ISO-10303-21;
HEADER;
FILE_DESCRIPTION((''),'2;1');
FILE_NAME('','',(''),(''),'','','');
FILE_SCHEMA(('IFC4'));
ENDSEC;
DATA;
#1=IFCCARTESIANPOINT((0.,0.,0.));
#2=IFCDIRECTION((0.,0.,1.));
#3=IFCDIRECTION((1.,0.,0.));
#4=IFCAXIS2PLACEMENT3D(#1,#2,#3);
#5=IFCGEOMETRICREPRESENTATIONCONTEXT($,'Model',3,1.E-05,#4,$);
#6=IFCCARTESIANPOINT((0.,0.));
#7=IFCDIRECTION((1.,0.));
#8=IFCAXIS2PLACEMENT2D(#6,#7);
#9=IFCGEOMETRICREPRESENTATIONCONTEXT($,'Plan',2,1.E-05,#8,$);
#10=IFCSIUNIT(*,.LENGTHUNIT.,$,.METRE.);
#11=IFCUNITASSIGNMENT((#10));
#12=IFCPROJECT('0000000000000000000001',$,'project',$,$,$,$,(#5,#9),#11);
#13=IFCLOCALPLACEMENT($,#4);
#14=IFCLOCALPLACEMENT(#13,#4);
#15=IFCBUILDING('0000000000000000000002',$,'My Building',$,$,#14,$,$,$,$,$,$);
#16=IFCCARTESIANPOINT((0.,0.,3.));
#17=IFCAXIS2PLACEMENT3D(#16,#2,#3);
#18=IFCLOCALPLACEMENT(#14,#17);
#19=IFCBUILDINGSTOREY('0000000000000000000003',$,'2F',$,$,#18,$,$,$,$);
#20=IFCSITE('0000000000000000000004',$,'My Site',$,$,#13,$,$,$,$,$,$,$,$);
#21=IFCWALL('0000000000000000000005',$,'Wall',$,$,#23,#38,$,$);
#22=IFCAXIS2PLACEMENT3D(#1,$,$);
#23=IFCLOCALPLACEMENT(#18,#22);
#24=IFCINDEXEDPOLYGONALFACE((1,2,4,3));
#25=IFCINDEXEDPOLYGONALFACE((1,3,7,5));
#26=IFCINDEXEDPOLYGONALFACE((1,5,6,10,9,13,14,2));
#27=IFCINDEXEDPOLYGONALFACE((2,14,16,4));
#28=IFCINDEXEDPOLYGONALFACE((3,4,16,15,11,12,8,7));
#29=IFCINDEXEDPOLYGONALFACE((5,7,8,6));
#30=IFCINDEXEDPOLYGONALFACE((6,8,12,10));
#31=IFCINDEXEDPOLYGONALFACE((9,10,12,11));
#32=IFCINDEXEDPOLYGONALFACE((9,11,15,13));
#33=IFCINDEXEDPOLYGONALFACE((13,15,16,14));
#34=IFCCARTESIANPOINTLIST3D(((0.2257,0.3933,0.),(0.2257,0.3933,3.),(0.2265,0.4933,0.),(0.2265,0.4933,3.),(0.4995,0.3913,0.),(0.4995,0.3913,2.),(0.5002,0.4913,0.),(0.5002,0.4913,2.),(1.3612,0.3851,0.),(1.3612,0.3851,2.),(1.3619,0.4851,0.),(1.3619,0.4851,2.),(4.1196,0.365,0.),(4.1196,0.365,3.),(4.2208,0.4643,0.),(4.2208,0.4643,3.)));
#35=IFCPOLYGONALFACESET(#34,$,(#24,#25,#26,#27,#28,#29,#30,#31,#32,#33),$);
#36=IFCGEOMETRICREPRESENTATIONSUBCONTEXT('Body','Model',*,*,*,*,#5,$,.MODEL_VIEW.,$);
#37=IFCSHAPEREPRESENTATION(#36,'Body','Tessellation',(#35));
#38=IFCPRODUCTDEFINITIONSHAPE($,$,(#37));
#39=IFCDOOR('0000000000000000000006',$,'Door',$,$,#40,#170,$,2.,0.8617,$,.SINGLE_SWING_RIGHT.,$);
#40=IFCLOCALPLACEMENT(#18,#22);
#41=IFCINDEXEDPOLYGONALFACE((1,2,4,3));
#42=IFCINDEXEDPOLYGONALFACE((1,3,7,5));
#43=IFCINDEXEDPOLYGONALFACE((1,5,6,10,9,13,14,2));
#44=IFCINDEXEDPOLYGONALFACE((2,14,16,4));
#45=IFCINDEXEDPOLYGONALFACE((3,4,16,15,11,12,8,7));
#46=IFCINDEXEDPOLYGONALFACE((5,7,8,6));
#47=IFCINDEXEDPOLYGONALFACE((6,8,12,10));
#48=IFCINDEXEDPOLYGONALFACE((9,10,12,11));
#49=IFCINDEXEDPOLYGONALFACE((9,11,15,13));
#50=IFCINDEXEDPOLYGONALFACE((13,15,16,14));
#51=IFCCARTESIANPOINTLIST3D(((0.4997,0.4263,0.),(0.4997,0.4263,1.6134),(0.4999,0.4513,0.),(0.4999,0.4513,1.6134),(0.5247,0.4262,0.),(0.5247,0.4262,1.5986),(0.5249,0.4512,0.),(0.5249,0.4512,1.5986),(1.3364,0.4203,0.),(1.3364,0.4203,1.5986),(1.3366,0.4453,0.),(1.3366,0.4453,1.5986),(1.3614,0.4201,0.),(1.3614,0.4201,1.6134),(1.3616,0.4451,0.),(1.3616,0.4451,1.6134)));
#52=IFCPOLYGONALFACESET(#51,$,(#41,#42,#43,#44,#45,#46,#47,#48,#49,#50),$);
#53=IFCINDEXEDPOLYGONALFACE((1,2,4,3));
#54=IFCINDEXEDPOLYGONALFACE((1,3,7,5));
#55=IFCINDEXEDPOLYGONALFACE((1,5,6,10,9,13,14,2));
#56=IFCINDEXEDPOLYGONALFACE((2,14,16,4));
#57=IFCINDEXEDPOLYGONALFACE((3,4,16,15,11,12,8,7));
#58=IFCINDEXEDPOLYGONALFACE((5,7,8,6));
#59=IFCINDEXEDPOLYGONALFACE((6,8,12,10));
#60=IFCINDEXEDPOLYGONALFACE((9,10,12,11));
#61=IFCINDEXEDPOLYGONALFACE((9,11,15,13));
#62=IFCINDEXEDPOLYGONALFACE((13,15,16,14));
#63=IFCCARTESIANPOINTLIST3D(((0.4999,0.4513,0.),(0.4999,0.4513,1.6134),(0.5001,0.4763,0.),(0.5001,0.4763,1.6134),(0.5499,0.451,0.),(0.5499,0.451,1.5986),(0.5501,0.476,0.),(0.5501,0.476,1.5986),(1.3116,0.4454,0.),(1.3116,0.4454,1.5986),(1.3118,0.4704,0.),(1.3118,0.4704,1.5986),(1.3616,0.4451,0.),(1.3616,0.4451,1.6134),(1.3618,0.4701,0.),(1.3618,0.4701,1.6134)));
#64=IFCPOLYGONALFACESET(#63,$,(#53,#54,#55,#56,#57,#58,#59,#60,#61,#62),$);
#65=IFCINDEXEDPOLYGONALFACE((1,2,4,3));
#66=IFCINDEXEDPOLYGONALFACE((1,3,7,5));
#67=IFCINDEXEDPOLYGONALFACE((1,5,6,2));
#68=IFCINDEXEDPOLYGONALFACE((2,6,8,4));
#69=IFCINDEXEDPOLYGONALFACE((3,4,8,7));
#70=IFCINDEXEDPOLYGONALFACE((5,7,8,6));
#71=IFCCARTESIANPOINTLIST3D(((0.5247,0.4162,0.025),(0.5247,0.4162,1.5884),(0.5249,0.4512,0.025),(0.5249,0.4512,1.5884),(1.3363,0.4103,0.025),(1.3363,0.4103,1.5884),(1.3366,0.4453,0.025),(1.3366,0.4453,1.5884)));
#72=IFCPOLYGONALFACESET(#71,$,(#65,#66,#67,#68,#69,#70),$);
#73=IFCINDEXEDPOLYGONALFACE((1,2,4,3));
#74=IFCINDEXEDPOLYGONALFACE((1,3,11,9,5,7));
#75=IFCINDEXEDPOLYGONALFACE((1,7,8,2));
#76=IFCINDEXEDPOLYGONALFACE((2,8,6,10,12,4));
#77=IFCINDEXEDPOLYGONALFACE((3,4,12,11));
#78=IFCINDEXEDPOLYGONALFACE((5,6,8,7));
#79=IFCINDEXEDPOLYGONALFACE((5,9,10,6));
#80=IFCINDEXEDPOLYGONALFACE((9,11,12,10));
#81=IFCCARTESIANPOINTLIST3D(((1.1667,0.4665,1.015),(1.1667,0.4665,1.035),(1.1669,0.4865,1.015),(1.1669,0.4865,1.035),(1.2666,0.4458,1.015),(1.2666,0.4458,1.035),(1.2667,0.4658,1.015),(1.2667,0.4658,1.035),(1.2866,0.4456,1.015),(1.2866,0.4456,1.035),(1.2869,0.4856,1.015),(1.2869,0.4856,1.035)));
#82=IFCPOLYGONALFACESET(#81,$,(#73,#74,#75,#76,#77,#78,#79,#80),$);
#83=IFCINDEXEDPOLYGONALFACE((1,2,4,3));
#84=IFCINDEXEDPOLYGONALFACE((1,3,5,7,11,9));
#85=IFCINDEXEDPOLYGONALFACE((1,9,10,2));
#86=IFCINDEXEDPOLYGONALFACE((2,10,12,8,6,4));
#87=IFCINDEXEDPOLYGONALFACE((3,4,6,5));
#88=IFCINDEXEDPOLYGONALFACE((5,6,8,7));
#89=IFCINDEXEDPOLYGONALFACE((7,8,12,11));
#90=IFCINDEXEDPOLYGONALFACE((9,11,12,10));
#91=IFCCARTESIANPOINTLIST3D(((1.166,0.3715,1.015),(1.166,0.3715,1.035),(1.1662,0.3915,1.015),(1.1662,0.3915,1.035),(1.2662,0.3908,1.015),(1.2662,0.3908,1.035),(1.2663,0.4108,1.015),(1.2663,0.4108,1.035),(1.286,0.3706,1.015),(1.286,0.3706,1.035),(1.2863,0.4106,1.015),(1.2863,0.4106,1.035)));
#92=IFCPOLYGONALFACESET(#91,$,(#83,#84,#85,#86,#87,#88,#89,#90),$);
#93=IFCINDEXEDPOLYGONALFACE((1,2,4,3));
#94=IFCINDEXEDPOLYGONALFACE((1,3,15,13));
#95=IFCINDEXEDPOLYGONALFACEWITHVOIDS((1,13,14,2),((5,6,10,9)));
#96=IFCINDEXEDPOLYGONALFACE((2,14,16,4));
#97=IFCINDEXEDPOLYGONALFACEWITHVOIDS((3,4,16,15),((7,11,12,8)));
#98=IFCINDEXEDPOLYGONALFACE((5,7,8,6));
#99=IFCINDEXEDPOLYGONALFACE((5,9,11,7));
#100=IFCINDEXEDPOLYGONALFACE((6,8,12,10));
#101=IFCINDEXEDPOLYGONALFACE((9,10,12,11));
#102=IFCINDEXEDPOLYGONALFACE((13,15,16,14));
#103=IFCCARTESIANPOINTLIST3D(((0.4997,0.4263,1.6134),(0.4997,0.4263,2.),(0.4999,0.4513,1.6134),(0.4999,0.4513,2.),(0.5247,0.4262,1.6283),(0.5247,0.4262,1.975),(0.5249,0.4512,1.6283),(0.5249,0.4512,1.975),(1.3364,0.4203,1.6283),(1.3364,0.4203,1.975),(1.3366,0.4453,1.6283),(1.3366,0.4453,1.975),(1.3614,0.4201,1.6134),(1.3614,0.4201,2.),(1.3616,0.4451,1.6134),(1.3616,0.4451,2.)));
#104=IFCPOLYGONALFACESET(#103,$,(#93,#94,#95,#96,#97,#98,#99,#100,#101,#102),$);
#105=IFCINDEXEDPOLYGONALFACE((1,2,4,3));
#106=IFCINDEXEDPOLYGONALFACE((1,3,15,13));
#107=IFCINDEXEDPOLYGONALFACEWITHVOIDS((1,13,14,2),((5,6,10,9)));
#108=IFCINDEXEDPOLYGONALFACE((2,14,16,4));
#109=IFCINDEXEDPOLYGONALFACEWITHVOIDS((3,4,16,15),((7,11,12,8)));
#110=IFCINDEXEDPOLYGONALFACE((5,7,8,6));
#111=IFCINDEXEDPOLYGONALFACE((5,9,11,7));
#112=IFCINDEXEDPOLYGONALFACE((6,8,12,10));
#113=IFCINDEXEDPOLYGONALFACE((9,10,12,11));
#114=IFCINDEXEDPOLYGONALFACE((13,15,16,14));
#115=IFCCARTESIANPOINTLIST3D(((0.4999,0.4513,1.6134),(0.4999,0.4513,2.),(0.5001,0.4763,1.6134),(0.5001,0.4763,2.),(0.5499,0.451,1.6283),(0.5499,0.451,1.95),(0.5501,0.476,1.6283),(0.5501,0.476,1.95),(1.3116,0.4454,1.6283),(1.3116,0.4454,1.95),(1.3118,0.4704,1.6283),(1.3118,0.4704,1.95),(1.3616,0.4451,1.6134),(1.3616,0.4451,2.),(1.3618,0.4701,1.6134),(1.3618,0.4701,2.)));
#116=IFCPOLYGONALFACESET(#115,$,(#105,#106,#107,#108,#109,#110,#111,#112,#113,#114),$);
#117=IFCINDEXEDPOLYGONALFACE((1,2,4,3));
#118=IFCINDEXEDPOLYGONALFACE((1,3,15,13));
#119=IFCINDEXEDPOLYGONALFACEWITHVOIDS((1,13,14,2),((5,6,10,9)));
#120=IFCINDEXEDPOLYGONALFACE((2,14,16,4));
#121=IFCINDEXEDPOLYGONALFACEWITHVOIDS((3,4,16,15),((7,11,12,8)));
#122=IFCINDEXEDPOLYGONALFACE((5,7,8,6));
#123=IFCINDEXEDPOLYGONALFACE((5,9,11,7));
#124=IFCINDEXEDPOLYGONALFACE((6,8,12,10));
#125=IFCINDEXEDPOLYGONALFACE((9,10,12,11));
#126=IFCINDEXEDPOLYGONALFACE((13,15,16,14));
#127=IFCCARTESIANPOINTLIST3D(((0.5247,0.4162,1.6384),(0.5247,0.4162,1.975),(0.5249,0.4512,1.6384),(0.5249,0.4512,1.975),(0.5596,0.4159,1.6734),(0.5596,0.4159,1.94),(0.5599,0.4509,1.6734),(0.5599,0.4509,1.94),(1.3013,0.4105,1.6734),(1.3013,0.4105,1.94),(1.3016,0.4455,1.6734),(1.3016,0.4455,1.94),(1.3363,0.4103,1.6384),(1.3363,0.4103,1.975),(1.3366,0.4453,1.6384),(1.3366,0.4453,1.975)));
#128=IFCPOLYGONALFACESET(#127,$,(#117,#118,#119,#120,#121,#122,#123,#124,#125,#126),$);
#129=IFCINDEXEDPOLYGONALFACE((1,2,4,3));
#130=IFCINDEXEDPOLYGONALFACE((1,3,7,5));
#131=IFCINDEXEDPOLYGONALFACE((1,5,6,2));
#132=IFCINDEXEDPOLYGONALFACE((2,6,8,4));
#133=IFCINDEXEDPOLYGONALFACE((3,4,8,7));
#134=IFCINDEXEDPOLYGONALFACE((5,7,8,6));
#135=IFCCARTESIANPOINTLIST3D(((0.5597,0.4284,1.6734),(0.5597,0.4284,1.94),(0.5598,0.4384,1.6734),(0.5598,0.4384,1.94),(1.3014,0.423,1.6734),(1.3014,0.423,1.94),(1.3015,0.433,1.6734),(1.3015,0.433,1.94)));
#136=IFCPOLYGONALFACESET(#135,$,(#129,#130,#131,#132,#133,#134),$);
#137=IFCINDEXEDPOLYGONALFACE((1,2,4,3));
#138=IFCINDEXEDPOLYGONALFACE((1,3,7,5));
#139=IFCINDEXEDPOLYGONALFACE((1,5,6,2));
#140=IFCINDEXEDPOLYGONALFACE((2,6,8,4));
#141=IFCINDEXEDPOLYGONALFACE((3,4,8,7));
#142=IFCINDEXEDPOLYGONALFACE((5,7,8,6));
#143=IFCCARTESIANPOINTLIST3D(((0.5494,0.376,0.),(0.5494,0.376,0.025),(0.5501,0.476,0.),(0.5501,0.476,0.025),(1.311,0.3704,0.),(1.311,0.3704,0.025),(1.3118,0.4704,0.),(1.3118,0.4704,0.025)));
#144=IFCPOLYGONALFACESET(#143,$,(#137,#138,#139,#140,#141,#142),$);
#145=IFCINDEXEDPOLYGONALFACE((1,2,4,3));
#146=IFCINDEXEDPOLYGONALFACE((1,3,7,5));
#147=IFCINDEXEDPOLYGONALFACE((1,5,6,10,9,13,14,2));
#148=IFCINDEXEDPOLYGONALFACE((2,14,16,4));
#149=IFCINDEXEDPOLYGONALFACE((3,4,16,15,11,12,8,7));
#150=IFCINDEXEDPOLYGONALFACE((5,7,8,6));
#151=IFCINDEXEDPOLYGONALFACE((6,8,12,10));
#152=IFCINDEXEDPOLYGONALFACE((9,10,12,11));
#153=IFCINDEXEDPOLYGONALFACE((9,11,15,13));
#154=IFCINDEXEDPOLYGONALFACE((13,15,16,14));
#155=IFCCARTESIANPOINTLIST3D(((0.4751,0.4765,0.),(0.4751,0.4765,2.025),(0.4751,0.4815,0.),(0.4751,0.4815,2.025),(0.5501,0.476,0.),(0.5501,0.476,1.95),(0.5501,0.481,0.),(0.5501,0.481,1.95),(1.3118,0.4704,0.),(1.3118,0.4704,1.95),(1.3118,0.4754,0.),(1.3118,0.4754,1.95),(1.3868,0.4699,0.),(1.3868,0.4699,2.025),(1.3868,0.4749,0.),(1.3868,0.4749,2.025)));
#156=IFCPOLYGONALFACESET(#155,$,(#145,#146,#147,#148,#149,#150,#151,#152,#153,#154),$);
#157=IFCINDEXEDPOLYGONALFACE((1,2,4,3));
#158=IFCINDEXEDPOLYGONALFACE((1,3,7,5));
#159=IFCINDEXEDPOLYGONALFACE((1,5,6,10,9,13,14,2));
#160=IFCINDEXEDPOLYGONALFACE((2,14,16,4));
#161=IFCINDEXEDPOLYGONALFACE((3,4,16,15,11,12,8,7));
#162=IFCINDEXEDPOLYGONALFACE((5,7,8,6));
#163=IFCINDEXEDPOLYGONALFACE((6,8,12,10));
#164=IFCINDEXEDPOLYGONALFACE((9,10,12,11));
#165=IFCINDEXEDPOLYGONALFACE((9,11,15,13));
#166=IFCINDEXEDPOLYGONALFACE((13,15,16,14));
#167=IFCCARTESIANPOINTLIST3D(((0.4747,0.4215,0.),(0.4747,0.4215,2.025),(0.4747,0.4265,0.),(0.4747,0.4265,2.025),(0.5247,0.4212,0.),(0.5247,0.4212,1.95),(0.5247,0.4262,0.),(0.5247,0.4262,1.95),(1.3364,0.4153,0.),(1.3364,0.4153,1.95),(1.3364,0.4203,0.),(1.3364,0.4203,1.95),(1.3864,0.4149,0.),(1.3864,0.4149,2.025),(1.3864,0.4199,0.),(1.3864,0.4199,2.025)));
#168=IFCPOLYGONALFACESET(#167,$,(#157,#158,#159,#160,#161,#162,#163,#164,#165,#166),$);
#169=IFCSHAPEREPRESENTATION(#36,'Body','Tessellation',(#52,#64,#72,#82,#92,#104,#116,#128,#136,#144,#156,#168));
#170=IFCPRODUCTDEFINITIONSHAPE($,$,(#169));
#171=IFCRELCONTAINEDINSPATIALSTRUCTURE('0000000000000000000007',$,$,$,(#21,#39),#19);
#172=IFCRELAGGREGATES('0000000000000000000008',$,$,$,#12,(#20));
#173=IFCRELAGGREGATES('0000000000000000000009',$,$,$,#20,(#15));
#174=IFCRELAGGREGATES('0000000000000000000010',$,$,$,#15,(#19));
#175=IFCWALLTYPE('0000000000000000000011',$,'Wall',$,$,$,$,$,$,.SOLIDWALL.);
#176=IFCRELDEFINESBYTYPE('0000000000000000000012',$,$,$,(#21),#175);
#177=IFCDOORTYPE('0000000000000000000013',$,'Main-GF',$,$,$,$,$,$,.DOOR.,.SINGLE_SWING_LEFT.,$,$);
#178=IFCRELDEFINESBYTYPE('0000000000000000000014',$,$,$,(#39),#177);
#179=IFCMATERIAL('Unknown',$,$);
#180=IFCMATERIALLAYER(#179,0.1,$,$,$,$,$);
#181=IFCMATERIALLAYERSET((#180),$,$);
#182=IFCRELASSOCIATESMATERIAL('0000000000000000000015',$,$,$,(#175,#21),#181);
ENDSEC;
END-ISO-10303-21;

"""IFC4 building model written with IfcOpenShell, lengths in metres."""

from ifc_helpers import new_model, entity, si_unit, frame, origin_with_axes, origin_2d_with_axis, place, context, subcontext, project, spatial, line, indexed_curve, outline, extrude, shape, source, transform, mapped, material, layer, layer_set, layer_usage, type_object, type_shapes, element, fill, save


model = new_model("IFC4")

# Units and contexts
model_context = context("Model", 3, precision=1e-05, world=origin_with_axes())
plan_context = context("Plan", 2, precision=1e-05, world=origin_2d_with_axis())
body_context_1 = subcontext(model_context, "Body", "Model", "MODEL_VIEW")
body_context_2 = subcontext(plan_context, "Body", "Plan", "PLAN_VIEW")
ifc_project = project(units=[si_unit("LENGTHUNIT", "METRE")], contexts=[model_context, plan_context])

# Site, building, storey
site_placement = place(None, origin_with_axes())
site = spatial("IfcSite", under=ifc_project, at=site_placement, Name="My Site")
building_placement = place(site_placement, origin_with_axes())
building = spatial("IfcBuilding", under=site, at=building_placement, Name="My Building")
storey_placement = place(building_placement, frame((0.0, 0.0, 3.0), z_axis=(0.0, 0.0, 1.0), x_axis=(1.0, 0.0, 0.0)))
storey = spatial("IfcBuildingStorey", under=building, at=storey_placement, Name="2F")

# Shared definitions
ifc_material = material(Name="Unknown")

# Shared definitions
ifc_layer = layer(ifc_material, 0.1)
ifc_layer_set = layer_set([ifc_layer])
wall_type = type_object("IfcWallType", Name="Wall", PredefinedType="SOLIDWALL", material=ifc_layer_set)

# Wall, opening, door
ifc_layer_usage_1 = layer_usage(ifc_layer_set, "AXIS2", "POSITIVE", 0.0)
wall_1_placement = place(storey_placement, frame((0.2257, 0.3933, 0.0), z_axis=(0.0, 0.0, 1.0), x_axis=(0.999974, -0.007275, 0.0)))
wall_1 = element("IfcWall", 1, at=wall_1_placement, inside=storey, type_object=wall_type, material=ifc_layer_usage_1, Name="Wall", context=body_context_1, shape_type="SweptSolid", body=[
    extrude(outline(indexed_curve([(0.0, 0.0), (0.0, 0.1), (3.9944, 0.1), (3.894, 0.0)], segments=[line(1, 2, 3, 4, 1)])), origin_with_axes(), (0.0, 0.0, 1.0), 3.0),
])
shared_shape_1 = source(origin_with_axes(), body_context_1, "Body", "SweptSolid", [
    extrude(outline(indexed_curve([(0.0, 0.0), (0.8617, 0.0), (0.8617, 2.0), (0.0, 2.0)], segments=[line(1, 2, 3, 4, 1)])), frame((0.0, -0.6, 0.0), z_axis=(0.0, -1.0, 0.0), x_axis=(1.0, 0.0, 0.0)), (0.0, 0.0, -1.0), 1.2),
])
opening_1_placement = place(wall_1_placement, frame((1.1354, 0.085, 0.0), z_axis=(0.0, 0.0, 1.0), x_axis=(-1.0, 0.0, 0.0)))
opening_1 = element("IfcOpeningElement", 2, at=opening_1_placement, cuts=wall_1, PredefinedType="OPENING", context=body_context_1, shape_type="MappedRepresentation", body=[
    mapped(shared_shape_1, transform((0.0, 0.0, 0.0), x_axis=(1.0, 0.0, 0.0), y_axis=(0.0, 1.0, 0.0), z_axis=(0.0, 0.0, 1.0), scale=1.0)),
])
door_type_1 = type_object("IfcDoorType", Name="Main-GF", OperationType="SINGLE_SWING_LEFT", PredefinedType="DOOR")
shared_shape_2 = source(origin_with_axes(), body_context_1, "Body", "SweptSolid", [
    extrude(outline(indexed_curve([(0.0, 0.0), (0.0, 1.6134), (0.8617, 1.6134), (0.8617, 0.0), (0.8367, 0.0), (0.8367, 1.5986), (0.025, 1.5986), (0.025, 0.0)], segments=[line(1, 2, 3, 4, 5, 6, 7, 8, 1)])), frame((0.0, 0.025, 0.0), z_axis=(0.0, -1.0, 0.0), x_axis=(1.0, 0.0, 0.0)), (0.0, 0.0, -1.0), 0.025),
    extrude(outline(indexed_curve([(0.0, 0.0), (0.0, 1.6134), (0.8617, 1.6134), (0.8617, 0.0), (0.8117, 0.0), (0.8117, 1.5986), (0.05, 1.5986), (0.05, 0.0)], segments=[line(1, 2, 3, 4, 5, 6, 7, 8, 1)])), frame((0.0, 0.0, 0.0), z_axis=(0.0, -1.0, 0.0), x_axis=(1.0, 0.0, 0.0)), (0.0, 0.0, -1.0), 0.025),
    extrude(outline(indexed_curve([(0.0, 0.0), (0.8117, 0.0), (0.8117, 0.035), (0.0, 0.035)], segments=[line(1, 2, 3, 4, 1)])), frame((0.025, 0.025, 0.025), z_axis=(0.0, 0.0, 1.0), x_axis=(1.0, 0.0, 0.0)), (0.0, 0.0, 1.0), 1.5634),
    extrude(outline(indexed_curve([(0.0, 0.0), (0.0, -0.04), (0.12, -0.04), (0.12, -0.02), (0.02, -0.02), (0.02, 0.0)], segments=[line(1, 2, 3, 4, 5, 6, 1)])), frame((0.075, 0.025, 1.015), z_axis=(0.0, 0.0, 1.0), x_axis=(1.0, 0.0, 0.0)), (0.0, 0.0, 1.0), 0.02),
    extrude(outline(indexed_curve([(0.0, 0.0), (0.0, 0.04), (0.12, 0.04), (0.12, 0.02), (0.02, 0.02), (0.02, 0.0)], segments=[line(1, 2, 3, 4, 5, 6, 1)])), frame((0.075, 0.06, 1.015), z_axis=(0.0, 0.0, 1.0), x_axis=(1.0, 0.0, 0.0)), (0.0, 0.0, 1.0), 0.02),
    extrude(outline(indexed_curve([(0.0, 0.0), (0.8617, 0.0), (0.8617, 0.3866), (0.0, 0.3866)], segments=[line(1, 2, 3, 4, 1)]), holes=[indexed_curve([(0.025, 0.0148), (0.8367, 0.0148), (0.8367, 0.3616), (0.025, 0.3616)], segments=[line(1, 2, 3, 4, 1)])]), frame((0.0, 0.025, 1.6134), z_axis=(0.0, -1.0, 0.0), x_axis=(1.0, 0.0, 0.0)), (0.0, 0.0, -1.0), 0.025),
    extrude(outline(indexed_curve([(0.0, 0.0), (0.8617, 0.0), (0.8617, 0.3866), (0.0, 0.3866)], segments=[line(1, 2, 3, 4, 1)]), holes=[indexed_curve([(0.05, 0.0148), (0.8117, 0.0148), (0.8117, 0.3366), (0.05, 0.3366)], segments=[line(1, 2, 3, 4, 1)])]), frame((0.0, 0.0, 1.6134), z_axis=(0.0, -1.0, 0.0), x_axis=(1.0, 0.0, 0.0)), (0.0, 0.0, -1.0), 0.025),
    extrude(outline(indexed_curve([(0.0, 0.0), (0.8117, 0.0), (0.8117, 0.3366), (0.0, 0.3366)], segments=[line(1, 2, 3, 4, 1)]), holes=[indexed_curve([(0.035, 0.035), (0.7767, 0.035), (0.7767, 0.3016), (0.035, 0.3016)], segments=[line(1, 2, 3, 4, 1)])]), frame((0.025, 0.025, 1.6384), z_axis=(0.0, -1.0, 0.0), x_axis=(1.0, 0.0, 0.0)), (0.0, 0.0, -1.0), 0.035),
    extrude(outline(indexed_curve([(0.035, 0.035), (0.7767, 0.035), (0.7767, 0.3016), (0.035, 0.3016)], segments=[line(1, 2, 3, 4, 1)])), frame((0.025, 0.0375, 1.6384), z_axis=(0.0, -1.0, 0.0), x_axis=(1.0, 0.0, 0.0)), (0.0, 0.0, -1.0), 0.01),
    extrude(outline(indexed_curve([(0.0, 0.0), (0.7617, 0.0), (0.7617, 0.1), (0.0, 0.1)], segments=[line(1, 2, 3, 4, 1)])), frame((0.05, 0.0, 0.0), z_axis=(0.0, 0.0, 1.0), x_axis=(1.0, 0.0, 0.0)), (0.0, 0.0, 1.0), 0.025),
    extrude(outline(indexed_curve([(0.0, 0.0), (0.0, 2.025), (0.9117, 2.025), (0.9117, 0.0), (0.8367, 0.0), (0.8367, 1.95), (0.075, 1.95), (0.075, 0.0)], segments=[line(1, 2, 3, 4, 5, 6, 7, 8, 1)])), frame((-0.025, -0.005, 0.0), z_axis=(0.0, -1.0, 0.0), x_axis=(1.0, 0.0, 0.0)), (0.0, 0.0, -1.0), 0.005),
    extrude(outline(indexed_curve([(0.0, 0.0), (0.0, 2.025), (0.9117, 2.025), (0.9117, 0.0), (0.8617, 0.0), (0.8617, 1.95), (0.05, 1.95), (0.05, 0.0)], segments=[line(1, 2, 3, 4, 5, 6, 7, 8, 1)])), frame((-0.025, 0.05, 0.0), z_axis=(0.0, -1.0, 0.0), x_axis=(1.0, 0.0, 0.0)), (0.0, 0.0, -1.0), 0.005),
])
shared_shape_3 = source(origin_with_axes(), body_context_2, "Body", "Curve2D", [
    entity("IfcIndexedPolyCurve", entity("IfcCartesianPointList2D", [[0.0, 0.0], [0.0, 0.05], [0.025, 0.05], [0.025, 0.025], [0.05, 0.025], [0.05, 0.0]]), [entity("IfcLineIndex", [1, 2, 3, 4, 5, 6, 1])]),
    entity("IfcIndexedPolyCurve", entity("IfcCartesianPointList2D", [[0.8617, 0.0], [0.8617, 0.05], [0.8367, 0.05], [0.8367, 0.025], [0.8117, 0.025], [0.8117, 0.0]]), [entity("IfcLineIndex", [1, 2, 3, 4, 5, 6, 1])]),
    entity("IfcTrimmedCurve", entity("IfcEllipse", entity("IfcAxis2Placement2D", entity("IfcCartesianPoint", [0.8017, 0.05]), entity("IfcDirection", [1.0, 0.0])), 0.7767, 0.8117), [entity("IfcCartesianPoint", [0.8017, 0.8617])], [entity("IfcCartesianPoint", [0.025, 0.05])], True, "CARTESIAN"),
    entity("IfcIndexedPolyCurve", entity("IfcCartesianPointList2D", [[0.8367, 0.05], [0.8017, 0.05], [0.8017, 0.8617], [0.8367, 0.8617]]), [entity("IfcLineIndex", [1, 2, 3, 4, 1])]),
])
type_shapes(door_type_1, [shared_shape_2, shared_shape_3])
door_1_placement = place(opening_1_placement, frame((0.0, 0.0, 0.0), z_axis=(0.0, 0.0, 1.0), x_axis=(1.0, 0.0, 0.0)))
door_1 = element("IfcDoor", 3, at=door_1_placement, inside=storey, type_object=door_type_1, Name="Door", OperationType="SINGLE_SWING_RIGHT", OverallHeight=2.0, OverallWidth=0.8617, shapes=[
    shape(body_context_1, "Body", "MappedRepresentation", [mapped(shared_shape_2, transform((0.0, 0.0, 0.0), x_axis=(1.0, 0.0, 0.0), y_axis=(0.0, 1.0, 0.0), z_axis=(0.0, 0.0, 1.0), scale=1.0))]),
    shape(body_context_2, "Body", "MappedRepresentation", [mapped(shared_shape_3, transform((0.0, 0.0, 0.0), x_axis=(1.0, 0.0, 0.0), y_axis=(0.0, 1.0, 0.0), z_axis=(0.0, 0.0, 1.0), scale=1.0))]),
])
fill(opening_1, door_1)

save(model, "model.ifc")
